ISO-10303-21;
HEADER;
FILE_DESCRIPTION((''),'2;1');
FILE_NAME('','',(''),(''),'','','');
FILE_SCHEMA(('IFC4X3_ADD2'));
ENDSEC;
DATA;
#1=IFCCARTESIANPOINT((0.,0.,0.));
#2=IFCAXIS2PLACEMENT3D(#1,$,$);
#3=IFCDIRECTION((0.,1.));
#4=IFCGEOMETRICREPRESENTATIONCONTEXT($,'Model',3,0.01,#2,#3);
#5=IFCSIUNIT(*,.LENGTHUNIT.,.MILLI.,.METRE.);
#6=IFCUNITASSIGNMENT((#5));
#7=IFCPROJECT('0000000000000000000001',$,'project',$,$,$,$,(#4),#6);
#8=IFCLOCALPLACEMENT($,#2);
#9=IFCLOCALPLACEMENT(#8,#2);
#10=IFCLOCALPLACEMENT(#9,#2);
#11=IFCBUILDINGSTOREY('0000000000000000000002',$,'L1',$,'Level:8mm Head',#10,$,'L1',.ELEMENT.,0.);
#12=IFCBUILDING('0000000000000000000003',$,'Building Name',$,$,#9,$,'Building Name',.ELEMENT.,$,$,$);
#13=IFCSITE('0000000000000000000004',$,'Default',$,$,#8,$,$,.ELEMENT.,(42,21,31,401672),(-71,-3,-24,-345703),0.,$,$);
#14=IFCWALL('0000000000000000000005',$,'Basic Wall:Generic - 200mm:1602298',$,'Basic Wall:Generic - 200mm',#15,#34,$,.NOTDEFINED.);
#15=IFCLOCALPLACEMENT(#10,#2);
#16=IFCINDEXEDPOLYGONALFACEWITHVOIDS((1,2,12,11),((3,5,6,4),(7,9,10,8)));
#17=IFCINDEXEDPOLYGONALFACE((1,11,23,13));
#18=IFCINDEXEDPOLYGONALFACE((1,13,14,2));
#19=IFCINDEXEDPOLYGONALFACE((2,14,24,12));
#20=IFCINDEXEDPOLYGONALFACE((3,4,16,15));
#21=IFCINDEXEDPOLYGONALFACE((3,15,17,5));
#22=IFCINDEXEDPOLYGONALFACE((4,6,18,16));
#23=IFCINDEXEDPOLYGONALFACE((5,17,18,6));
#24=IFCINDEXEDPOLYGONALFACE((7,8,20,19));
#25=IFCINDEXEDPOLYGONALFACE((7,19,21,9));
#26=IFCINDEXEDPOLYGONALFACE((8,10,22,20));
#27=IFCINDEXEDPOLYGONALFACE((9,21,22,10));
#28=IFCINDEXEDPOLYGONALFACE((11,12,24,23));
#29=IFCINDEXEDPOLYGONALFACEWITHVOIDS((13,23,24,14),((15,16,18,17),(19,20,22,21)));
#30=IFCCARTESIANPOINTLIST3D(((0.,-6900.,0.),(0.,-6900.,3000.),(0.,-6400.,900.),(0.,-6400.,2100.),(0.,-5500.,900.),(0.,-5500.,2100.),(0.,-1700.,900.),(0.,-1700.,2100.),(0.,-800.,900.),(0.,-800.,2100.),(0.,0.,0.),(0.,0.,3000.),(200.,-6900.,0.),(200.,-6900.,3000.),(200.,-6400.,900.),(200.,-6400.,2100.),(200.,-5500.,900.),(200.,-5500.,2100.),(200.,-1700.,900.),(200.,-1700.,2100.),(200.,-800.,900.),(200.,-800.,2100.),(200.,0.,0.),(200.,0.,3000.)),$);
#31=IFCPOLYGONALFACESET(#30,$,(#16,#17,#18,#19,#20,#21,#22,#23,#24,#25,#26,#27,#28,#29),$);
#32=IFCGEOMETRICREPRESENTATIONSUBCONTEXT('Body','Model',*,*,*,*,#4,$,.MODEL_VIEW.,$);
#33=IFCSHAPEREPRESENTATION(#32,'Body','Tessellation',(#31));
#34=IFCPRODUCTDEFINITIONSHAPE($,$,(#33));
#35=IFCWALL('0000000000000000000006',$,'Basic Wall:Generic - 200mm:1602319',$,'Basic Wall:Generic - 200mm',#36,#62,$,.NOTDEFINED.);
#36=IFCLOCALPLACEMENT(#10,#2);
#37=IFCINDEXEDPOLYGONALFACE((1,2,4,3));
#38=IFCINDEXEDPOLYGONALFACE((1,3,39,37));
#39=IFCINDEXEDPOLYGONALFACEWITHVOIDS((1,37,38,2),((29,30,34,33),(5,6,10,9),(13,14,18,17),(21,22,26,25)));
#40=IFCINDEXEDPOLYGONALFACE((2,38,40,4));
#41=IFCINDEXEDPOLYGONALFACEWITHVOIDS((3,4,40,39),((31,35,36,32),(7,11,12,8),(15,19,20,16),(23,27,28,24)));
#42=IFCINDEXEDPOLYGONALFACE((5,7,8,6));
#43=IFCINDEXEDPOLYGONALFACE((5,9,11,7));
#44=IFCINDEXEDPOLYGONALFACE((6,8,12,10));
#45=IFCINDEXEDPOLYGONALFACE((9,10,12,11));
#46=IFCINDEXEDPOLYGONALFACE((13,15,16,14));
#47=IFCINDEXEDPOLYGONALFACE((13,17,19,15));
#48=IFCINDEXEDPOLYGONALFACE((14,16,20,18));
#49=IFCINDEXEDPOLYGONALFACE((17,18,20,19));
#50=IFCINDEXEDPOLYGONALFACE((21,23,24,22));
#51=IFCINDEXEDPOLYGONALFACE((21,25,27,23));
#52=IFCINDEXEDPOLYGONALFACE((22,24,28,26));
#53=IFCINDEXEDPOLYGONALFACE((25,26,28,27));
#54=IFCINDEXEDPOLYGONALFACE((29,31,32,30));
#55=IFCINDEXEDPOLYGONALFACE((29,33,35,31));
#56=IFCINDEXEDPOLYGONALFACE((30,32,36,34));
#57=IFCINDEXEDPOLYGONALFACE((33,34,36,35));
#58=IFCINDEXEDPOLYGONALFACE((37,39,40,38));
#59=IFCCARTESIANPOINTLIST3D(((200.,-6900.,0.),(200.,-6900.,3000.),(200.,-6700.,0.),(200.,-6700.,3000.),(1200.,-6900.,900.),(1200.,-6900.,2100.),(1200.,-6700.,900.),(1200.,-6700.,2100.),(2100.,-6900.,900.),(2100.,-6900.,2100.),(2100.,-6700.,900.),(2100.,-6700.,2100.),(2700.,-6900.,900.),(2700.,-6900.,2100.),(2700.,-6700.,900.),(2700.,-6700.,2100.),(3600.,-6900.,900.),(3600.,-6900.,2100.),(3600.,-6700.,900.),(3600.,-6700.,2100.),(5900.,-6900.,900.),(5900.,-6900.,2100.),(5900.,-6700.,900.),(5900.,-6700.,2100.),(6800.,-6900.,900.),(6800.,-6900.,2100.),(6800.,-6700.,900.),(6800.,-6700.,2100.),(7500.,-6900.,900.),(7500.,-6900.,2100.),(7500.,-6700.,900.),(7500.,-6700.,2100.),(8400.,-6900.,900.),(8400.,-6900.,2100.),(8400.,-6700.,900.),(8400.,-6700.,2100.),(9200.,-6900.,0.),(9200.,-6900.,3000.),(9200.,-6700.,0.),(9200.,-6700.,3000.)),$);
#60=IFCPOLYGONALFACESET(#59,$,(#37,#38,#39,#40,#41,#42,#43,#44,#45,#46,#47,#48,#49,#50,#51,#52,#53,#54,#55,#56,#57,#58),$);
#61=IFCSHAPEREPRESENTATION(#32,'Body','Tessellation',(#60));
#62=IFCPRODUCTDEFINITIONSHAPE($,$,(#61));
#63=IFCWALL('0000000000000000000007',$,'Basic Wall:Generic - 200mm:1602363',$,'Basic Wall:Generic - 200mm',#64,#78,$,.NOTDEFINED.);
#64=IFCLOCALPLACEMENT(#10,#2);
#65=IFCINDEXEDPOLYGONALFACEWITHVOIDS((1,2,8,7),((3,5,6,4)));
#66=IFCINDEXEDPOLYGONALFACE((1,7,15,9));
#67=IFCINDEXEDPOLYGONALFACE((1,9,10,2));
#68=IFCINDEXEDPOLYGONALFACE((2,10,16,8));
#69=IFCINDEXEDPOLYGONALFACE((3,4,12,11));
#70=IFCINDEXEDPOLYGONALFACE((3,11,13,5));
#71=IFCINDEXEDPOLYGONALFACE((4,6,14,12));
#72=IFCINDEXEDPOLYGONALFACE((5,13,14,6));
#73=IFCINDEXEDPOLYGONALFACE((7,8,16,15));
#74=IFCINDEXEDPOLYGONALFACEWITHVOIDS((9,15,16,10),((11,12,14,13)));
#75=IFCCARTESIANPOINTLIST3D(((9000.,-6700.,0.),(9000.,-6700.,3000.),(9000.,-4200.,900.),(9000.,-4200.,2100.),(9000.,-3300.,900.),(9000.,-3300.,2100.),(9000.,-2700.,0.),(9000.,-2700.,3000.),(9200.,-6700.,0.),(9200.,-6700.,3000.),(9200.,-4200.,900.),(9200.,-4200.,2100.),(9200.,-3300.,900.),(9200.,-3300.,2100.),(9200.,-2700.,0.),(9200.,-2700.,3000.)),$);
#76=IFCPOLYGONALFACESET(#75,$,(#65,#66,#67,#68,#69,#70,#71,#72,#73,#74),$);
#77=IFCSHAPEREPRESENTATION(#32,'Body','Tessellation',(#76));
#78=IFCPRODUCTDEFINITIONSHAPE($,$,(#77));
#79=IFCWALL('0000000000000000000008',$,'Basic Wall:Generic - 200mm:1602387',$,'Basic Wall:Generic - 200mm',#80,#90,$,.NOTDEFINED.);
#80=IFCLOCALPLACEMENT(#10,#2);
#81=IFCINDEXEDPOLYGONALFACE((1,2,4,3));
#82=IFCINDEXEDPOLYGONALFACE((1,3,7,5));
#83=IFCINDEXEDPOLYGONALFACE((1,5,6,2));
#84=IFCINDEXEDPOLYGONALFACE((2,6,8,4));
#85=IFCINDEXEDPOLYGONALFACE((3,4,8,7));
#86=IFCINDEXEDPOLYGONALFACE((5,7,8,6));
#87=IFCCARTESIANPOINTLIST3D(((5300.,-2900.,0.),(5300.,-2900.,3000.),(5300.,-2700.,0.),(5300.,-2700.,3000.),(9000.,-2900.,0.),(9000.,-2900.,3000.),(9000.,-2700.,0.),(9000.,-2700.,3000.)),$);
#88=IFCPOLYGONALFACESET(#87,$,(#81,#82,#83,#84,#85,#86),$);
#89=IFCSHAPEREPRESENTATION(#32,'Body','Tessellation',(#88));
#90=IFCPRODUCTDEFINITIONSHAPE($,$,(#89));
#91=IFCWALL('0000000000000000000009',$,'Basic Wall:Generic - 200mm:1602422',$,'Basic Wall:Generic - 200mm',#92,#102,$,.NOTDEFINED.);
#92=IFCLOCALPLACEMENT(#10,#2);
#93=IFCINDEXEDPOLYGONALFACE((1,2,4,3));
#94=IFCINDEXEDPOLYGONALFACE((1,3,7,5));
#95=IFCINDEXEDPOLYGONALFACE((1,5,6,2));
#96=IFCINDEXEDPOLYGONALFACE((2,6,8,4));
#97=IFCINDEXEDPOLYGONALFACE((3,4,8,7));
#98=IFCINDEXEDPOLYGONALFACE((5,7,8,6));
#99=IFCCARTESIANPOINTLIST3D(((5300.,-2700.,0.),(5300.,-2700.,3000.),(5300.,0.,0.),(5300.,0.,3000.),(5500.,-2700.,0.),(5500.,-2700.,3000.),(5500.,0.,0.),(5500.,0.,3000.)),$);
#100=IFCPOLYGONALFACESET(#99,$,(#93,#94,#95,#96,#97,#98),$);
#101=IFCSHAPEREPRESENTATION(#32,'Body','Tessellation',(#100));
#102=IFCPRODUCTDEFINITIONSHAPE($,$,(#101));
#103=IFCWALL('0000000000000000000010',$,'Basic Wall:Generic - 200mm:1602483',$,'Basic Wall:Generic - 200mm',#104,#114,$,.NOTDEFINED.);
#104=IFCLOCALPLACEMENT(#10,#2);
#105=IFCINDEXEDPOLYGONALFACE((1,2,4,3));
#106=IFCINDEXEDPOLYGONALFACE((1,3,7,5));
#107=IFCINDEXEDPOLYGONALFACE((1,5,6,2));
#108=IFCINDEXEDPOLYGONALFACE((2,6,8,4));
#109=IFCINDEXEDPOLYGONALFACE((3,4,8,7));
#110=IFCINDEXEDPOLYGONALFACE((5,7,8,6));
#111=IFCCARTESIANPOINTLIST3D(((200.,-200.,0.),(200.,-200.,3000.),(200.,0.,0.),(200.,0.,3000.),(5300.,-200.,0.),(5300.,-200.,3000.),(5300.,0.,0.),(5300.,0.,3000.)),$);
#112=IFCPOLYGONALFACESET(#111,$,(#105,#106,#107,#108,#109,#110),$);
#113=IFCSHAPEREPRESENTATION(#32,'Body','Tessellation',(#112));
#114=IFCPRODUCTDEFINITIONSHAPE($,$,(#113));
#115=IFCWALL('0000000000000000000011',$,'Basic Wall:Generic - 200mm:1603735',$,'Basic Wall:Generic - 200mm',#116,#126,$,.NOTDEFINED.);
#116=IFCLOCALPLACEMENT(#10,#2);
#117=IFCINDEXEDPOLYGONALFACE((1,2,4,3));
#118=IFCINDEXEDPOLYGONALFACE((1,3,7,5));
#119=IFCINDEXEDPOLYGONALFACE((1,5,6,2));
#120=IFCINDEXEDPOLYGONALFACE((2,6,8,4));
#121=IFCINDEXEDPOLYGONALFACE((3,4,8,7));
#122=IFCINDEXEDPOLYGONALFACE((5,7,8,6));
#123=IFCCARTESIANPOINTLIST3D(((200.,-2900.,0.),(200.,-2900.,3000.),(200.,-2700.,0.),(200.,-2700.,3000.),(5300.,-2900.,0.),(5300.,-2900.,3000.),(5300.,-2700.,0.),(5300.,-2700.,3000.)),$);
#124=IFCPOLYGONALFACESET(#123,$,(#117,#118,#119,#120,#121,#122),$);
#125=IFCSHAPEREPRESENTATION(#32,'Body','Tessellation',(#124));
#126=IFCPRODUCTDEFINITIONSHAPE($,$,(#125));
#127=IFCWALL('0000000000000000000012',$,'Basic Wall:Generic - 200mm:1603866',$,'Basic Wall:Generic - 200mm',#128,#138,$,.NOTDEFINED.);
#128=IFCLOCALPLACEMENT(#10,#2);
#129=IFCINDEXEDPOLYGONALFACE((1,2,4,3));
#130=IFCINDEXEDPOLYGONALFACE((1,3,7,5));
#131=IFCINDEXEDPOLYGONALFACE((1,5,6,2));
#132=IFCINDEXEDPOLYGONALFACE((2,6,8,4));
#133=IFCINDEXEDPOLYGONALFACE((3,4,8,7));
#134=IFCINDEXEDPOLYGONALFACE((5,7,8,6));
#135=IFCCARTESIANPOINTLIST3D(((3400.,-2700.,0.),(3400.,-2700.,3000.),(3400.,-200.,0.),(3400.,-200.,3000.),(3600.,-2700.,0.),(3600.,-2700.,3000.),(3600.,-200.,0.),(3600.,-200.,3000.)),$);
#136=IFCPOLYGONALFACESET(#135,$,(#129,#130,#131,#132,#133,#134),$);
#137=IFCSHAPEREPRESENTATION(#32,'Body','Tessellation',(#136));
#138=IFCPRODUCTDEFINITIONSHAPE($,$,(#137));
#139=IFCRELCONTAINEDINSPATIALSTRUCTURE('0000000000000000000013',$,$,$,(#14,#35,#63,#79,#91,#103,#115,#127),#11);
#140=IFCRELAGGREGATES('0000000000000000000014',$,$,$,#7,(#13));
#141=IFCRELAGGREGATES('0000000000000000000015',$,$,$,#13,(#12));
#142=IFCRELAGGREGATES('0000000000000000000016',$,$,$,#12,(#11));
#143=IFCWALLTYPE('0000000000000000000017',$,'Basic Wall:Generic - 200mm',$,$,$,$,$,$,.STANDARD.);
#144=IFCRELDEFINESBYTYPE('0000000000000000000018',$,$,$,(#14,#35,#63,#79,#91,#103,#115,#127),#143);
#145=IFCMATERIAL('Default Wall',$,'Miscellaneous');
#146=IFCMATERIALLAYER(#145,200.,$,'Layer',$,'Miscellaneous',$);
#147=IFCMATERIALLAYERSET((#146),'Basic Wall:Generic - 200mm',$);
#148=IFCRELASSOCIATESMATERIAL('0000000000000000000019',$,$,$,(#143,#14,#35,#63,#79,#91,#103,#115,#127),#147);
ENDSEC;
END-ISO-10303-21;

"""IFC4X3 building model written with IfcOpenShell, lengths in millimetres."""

from ifc_helpers import new_model, si_unit, direction, frame, frame_2d, origin, place, context, subcontext, project, spatial, rectangle, extrude, material, layer, layer_set, type_object, element, save


model = new_model("IFC4X3")

# Units and contexts
model_context = context("Model", 3, precision=0.01, world=origin(), true_north=direction((0.0, 1.0)))
body_context = subcontext(model_context, "Body", "Model", "MODEL_VIEW")
ifc_project = project(units=[si_unit("LENGTHUNIT", "METRE", prefix="MILLI")], contexts=[model_context])

# Site, building, storey
site_placement = place(None, origin())
site = spatial("IfcSite", under=ifc_project, at=site_placement, Name="Default", CompositionType="ELEMENT", RefLatitude=(42, 21, 31, 401672), RefLongitude=(-71, -3, -24, -345703), RefElevation=0.0)
building_placement = place(site_placement, origin())
building = spatial("IfcBuilding", under=site, at=building_placement, Name="Building Name", LongName="Building Name", CompositionType="ELEMENT")
storey_placement = place(building_placement, origin())
storey = spatial("IfcBuildingStorey", under=building, at=storey_placement, Name="L1", ObjectType="Level:8mm Head", LongName="L1", CompositionType="ELEMENT", Elevation=0.0)

# Walls, openings
ifc_material = material(Name="Default Wall", Category="Miscellaneous")
ifc_layer = layer(ifc_material, 200.0, Name="Layer", Category="Miscellaneous")
ifc_layer_set = layer_set([ifc_layer], Name="Basic Wall:Generic - 200mm")
wall_type = type_object("IfcWallType", Name="Basic Wall:Generic - 200mm", PredefinedType="STANDARD", material=ifc_layer_set)
wall_1_placement = place(storey_placement, frame((100.0, 0.0, 0.0), z_axis=(0.0, 0.0, 1.0), x_axis=(0.0, -1.0, 0.0)))
wall_1 = element("IfcWall", 1, at=wall_1_placement, inside=storey, type_object=wall_type, material=ifc_layer_set, Name="Basic Wall:Generic - 200mm:1602298", ObjectType="Basic Wall:Generic - 200mm", PredefinedType="NOTDEFINED", context=body_context, shape_type="SweptSolid", body=[
    extrude(rectangle(XDim=6900.0, YDim=200.0, at=frame_2d((3450.0, 0.0), x_axis=(-1.0, 0.0))), origin(), (0.0, 0.0, 1.0), 3000.0),
])
opening_1_placement = place(wall_1_placement, frame((1700.0, 100.0, 900.0)))
element("IfcOpeningElement", 2, at=opening_1_placement, cuts=wall_1, PredefinedType="OPENING", context=body_context, shape_type="SweptSolid", body=[
    extrude(rectangle(XDim=1200.0, YDim=900.0, at=frame_2d((600.0, 450.0), x_axis=(-1.0, 0.0))), frame((0.0, 0.0, 0.0), z_axis=(0.0, -1.0, 0.0), x_axis=(0.0, 0.0, 1.0)), (0.0, 0.0, 1.0), 200.0),
])
opening_2_placement = place(wall_1_placement, frame((6400.0, 100.0, 900.0)))
element("IfcOpeningElement", 3, at=opening_2_placement, cuts=wall_1, PredefinedType="OPENING", context=body_context, shape_type="SweptSolid", body=[
    extrude(rectangle(XDim=1200.0, YDim=900.0, at=frame_2d((600.0, 450.0), x_axis=(-1.0, 0.0))), frame((0.0, 0.0, 0.0), z_axis=(0.0, -1.0, 0.0), x_axis=(0.0, 0.0, 1.0)), (0.0, 0.0, 1.0), 200.0),
])
wall_2_placement = place(storey_placement, frame((200.0, -6800.0, 0.0)))
wall_2 = element("IfcWall", 4, at=wall_2_placement, inside=storey, type_object=wall_type, material=ifc_layer_set, Name="Basic Wall:Generic - 200mm:1602319", ObjectType="Basic Wall:Generic - 200mm", PredefinedType="NOTDEFINED", context=body_context, shape_type="SweptSolid", body=[
    extrude(rectangle(XDim=9000.0, YDim=200.0, at=frame_2d((4500.0, 0.0), x_axis=(-1.0, 0.0))), origin(), (0.0, 0.0, 1.0), 3000.0),
])
opening_3_placement = place(wall_2_placement, frame((1900.0, 100.0, 900.0)))
element("IfcOpeningElement", 5, at=opening_3_placement, cuts=wall_2, PredefinedType="OPENING", context=body_context, shape_type="SweptSolid", body=[
    extrude(rectangle(XDim=1200.0, YDim=900.0, at=frame_2d((600.0, 450.0), x_axis=(-1.0, 0.0))), frame((0.0, 0.0, 0.0), z_axis=(0.0, -1.0, 0.0), x_axis=(0.0, 0.0, 1.0)), (0.0, 0.0, 1.0), 200.0),
])
opening_4_placement = place(wall_2_placement, frame((3400.0, 100.0, 900.0)))
element("IfcOpeningElement", 6, at=opening_4_placement, cuts=wall_2, PredefinedType="OPENING", context=body_context, shape_type="SweptSolid", body=[
    extrude(rectangle(XDim=1200.0, YDim=900.0, at=frame_2d((600.0, 450.0), x_axis=(-1.0, 0.0))), frame((0.0, 0.0, 0.0), z_axis=(0.0, -1.0, 0.0), x_axis=(0.0, 0.0, 1.0)), (0.0, 0.0, 1.0), 200.0),
])
opening_5_placement = place(wall_2_placement, frame((8200.0, 100.0, 900.0)))
element("IfcOpeningElement", 7, at=opening_5_placement, cuts=wall_2, PredefinedType="OPENING", context=body_context, shape_type="SweptSolid", body=[
    extrude(rectangle(XDim=1200.0, YDim=900.0, at=frame_2d((600.0, 450.0), x_axis=(-1.0, 0.0))), frame((0.0, 0.0, 0.0), z_axis=(0.0, -1.0, 0.0), x_axis=(0.0, 0.0, 1.0)), (0.0, 0.0, 1.0), 200.0),
])
opening_6_placement = place(wall_2_placement, frame((6600.0, 100.0, 900.0)))
element("IfcOpeningElement", 8, at=opening_6_placement, cuts=wall_2, PredefinedType="OPENING", context=body_context, shape_type="SweptSolid", body=[
    extrude(rectangle(XDim=1200.0, YDim=900.0, at=frame_2d((600.0, 450.0), x_axis=(-1.0, 0.0))), frame((0.0, 0.0, 0.0), z_axis=(0.0, -1.0, 0.0), x_axis=(0.0, 0.0, 1.0)), (0.0, 0.0, 1.0), 200.0),
])

# Wall, opening
wall_3_placement = place(storey_placement, frame((9100.0, -6700.0, 0.0), z_axis=(0.0, 0.0, 1.0), x_axis=(0.0, 1.0, 0.0)))
wall_3 = element("IfcWall", 9, at=wall_3_placement, inside=storey, type_object=wall_type, material=ifc_layer_set, Name="Basic Wall:Generic - 200mm:1602363", ObjectType="Basic Wall:Generic - 200mm", PredefinedType="NOTDEFINED", context=body_context, shape_type="SweptSolid", body=[
    extrude(rectangle(XDim=4000.0, YDim=200.0, at=frame_2d((2000.0, 0.0), x_axis=(-1.0, 0.0))), origin(), (0.0, 0.0, 1.0), 3000.0),
])
opening_7_placement = place(wall_3_placement, frame((3400.0, 100.0, 900.0)))
element("IfcOpeningElement", 10, at=opening_7_placement, cuts=wall_3, PredefinedType="OPENING", context=body_context, shape_type="SweptSolid", body=[
    extrude(rectangle(XDim=1200.0, YDim=900.0, at=frame_2d((600.0, 450.0), x_axis=(-1.0, 0.0))), frame((0.0, 0.0, 0.0), z_axis=(0.0, -1.0, 0.0), x_axis=(0.0, 0.0, 1.0)), (0.0, 0.0, 1.0), 200.0),
])

# Walls
wall_4_placement = place(storey_placement, frame((9000.0, -2800.0, 0.0), z_axis=(0.0, 0.0, 1.0), x_axis=(-1.0, 0.0, 0.0)))
element("IfcWall", 11, at=wall_4_placement, inside=storey, type_object=wall_type, material=ifc_layer_set, Name="Basic Wall:Generic - 200mm:1602387", ObjectType="Basic Wall:Generic - 200mm", PredefinedType="NOTDEFINED", context=body_context, shape_type="SweptSolid", body=[
    extrude(rectangle(XDim=3700.0, YDim=200.0, at=frame_2d((1850.0, 0.0), x_axis=(-1.0, 0.0))), origin(), (0.0, 0.0, 1.0), 3000.0),
])
wall_5_placement = place(storey_placement, frame((5400.0, -2700.0, 0.0), z_axis=(0.0, 0.0, 1.0), x_axis=(0.0, 1.0, 0.0)))
element("IfcWall", 12, at=wall_5_placement, inside=storey, type_object=wall_type, material=ifc_layer_set, Name="Basic Wall:Generic - 200mm:1602422", ObjectType="Basic Wall:Generic - 200mm", PredefinedType="NOTDEFINED", context=body_context, shape_type="SweptSolid", body=[
    extrude(rectangle(XDim=2700.0, YDim=200.0, at=frame_2d((1350.0, 0.0), x_axis=(-1.0, 0.0))), origin(), (0.0, 0.0, 1.0), 3000.0),
])
wall_6_placement = place(storey_placement, frame((5300.0, -100.0, 0.0), z_axis=(0.0, 0.0, 1.0), x_axis=(-1.0, 0.0, 0.0)))
element("IfcWall", 13, at=wall_6_placement, inside=storey, type_object=wall_type, material=ifc_layer_set, Name="Basic Wall:Generic - 200mm:1602483", ObjectType="Basic Wall:Generic - 200mm", PredefinedType="NOTDEFINED", context=body_context, shape_type="SweptSolid", body=[
    extrude(rectangle(XDim=5100.0, YDim=200.0, at=frame_2d((2550.0, 0.0), x_axis=(-1.0, 0.0))), origin(), (0.0, 0.0, 1.0), 3000.0),
])
wall_7_placement = place(storey_placement, frame((200.0, -2800.0, 0.0)))
element("IfcWall", 14, at=wall_7_placement, inside=storey, type_object=wall_type, material=ifc_layer_set, Name="Basic Wall:Generic - 200mm:1603735", ObjectType="Basic Wall:Generic - 200mm", PredefinedType="NOTDEFINED", context=body_context, shape_type="SweptSolid", body=[
    extrude(rectangle(XDim=5100.0, YDim=200.0, at=frame_2d((2550.0, 0.0), x_axis=(-1.0, 0.0))), origin(), (0.0, 0.0, 1.0), 3000.0),
])
wall_8_placement = place(storey_placement, frame((3500.0, -2700.0, 0.0), z_axis=(0.0, 0.0, 1.0), x_axis=(0.0, 1.0, 0.0)))
element("IfcWall", 15, at=wall_8_placement, inside=storey, type_object=wall_type, material=ifc_layer_set, Name="Basic Wall:Generic - 200mm:1603866", ObjectType="Basic Wall:Generic - 200mm", PredefinedType="NOTDEFINED", context=body_context, shape_type="SweptSolid", body=[
    extrude(rectangle(XDim=2500.0, YDim=200.0, at=frame_2d((1250.0, 0.0), x_axis=(-1.0, 0.0))), origin(), (0.0, 0.0, 1.0), 3000.0),
])

save(model, "model.ifc")
